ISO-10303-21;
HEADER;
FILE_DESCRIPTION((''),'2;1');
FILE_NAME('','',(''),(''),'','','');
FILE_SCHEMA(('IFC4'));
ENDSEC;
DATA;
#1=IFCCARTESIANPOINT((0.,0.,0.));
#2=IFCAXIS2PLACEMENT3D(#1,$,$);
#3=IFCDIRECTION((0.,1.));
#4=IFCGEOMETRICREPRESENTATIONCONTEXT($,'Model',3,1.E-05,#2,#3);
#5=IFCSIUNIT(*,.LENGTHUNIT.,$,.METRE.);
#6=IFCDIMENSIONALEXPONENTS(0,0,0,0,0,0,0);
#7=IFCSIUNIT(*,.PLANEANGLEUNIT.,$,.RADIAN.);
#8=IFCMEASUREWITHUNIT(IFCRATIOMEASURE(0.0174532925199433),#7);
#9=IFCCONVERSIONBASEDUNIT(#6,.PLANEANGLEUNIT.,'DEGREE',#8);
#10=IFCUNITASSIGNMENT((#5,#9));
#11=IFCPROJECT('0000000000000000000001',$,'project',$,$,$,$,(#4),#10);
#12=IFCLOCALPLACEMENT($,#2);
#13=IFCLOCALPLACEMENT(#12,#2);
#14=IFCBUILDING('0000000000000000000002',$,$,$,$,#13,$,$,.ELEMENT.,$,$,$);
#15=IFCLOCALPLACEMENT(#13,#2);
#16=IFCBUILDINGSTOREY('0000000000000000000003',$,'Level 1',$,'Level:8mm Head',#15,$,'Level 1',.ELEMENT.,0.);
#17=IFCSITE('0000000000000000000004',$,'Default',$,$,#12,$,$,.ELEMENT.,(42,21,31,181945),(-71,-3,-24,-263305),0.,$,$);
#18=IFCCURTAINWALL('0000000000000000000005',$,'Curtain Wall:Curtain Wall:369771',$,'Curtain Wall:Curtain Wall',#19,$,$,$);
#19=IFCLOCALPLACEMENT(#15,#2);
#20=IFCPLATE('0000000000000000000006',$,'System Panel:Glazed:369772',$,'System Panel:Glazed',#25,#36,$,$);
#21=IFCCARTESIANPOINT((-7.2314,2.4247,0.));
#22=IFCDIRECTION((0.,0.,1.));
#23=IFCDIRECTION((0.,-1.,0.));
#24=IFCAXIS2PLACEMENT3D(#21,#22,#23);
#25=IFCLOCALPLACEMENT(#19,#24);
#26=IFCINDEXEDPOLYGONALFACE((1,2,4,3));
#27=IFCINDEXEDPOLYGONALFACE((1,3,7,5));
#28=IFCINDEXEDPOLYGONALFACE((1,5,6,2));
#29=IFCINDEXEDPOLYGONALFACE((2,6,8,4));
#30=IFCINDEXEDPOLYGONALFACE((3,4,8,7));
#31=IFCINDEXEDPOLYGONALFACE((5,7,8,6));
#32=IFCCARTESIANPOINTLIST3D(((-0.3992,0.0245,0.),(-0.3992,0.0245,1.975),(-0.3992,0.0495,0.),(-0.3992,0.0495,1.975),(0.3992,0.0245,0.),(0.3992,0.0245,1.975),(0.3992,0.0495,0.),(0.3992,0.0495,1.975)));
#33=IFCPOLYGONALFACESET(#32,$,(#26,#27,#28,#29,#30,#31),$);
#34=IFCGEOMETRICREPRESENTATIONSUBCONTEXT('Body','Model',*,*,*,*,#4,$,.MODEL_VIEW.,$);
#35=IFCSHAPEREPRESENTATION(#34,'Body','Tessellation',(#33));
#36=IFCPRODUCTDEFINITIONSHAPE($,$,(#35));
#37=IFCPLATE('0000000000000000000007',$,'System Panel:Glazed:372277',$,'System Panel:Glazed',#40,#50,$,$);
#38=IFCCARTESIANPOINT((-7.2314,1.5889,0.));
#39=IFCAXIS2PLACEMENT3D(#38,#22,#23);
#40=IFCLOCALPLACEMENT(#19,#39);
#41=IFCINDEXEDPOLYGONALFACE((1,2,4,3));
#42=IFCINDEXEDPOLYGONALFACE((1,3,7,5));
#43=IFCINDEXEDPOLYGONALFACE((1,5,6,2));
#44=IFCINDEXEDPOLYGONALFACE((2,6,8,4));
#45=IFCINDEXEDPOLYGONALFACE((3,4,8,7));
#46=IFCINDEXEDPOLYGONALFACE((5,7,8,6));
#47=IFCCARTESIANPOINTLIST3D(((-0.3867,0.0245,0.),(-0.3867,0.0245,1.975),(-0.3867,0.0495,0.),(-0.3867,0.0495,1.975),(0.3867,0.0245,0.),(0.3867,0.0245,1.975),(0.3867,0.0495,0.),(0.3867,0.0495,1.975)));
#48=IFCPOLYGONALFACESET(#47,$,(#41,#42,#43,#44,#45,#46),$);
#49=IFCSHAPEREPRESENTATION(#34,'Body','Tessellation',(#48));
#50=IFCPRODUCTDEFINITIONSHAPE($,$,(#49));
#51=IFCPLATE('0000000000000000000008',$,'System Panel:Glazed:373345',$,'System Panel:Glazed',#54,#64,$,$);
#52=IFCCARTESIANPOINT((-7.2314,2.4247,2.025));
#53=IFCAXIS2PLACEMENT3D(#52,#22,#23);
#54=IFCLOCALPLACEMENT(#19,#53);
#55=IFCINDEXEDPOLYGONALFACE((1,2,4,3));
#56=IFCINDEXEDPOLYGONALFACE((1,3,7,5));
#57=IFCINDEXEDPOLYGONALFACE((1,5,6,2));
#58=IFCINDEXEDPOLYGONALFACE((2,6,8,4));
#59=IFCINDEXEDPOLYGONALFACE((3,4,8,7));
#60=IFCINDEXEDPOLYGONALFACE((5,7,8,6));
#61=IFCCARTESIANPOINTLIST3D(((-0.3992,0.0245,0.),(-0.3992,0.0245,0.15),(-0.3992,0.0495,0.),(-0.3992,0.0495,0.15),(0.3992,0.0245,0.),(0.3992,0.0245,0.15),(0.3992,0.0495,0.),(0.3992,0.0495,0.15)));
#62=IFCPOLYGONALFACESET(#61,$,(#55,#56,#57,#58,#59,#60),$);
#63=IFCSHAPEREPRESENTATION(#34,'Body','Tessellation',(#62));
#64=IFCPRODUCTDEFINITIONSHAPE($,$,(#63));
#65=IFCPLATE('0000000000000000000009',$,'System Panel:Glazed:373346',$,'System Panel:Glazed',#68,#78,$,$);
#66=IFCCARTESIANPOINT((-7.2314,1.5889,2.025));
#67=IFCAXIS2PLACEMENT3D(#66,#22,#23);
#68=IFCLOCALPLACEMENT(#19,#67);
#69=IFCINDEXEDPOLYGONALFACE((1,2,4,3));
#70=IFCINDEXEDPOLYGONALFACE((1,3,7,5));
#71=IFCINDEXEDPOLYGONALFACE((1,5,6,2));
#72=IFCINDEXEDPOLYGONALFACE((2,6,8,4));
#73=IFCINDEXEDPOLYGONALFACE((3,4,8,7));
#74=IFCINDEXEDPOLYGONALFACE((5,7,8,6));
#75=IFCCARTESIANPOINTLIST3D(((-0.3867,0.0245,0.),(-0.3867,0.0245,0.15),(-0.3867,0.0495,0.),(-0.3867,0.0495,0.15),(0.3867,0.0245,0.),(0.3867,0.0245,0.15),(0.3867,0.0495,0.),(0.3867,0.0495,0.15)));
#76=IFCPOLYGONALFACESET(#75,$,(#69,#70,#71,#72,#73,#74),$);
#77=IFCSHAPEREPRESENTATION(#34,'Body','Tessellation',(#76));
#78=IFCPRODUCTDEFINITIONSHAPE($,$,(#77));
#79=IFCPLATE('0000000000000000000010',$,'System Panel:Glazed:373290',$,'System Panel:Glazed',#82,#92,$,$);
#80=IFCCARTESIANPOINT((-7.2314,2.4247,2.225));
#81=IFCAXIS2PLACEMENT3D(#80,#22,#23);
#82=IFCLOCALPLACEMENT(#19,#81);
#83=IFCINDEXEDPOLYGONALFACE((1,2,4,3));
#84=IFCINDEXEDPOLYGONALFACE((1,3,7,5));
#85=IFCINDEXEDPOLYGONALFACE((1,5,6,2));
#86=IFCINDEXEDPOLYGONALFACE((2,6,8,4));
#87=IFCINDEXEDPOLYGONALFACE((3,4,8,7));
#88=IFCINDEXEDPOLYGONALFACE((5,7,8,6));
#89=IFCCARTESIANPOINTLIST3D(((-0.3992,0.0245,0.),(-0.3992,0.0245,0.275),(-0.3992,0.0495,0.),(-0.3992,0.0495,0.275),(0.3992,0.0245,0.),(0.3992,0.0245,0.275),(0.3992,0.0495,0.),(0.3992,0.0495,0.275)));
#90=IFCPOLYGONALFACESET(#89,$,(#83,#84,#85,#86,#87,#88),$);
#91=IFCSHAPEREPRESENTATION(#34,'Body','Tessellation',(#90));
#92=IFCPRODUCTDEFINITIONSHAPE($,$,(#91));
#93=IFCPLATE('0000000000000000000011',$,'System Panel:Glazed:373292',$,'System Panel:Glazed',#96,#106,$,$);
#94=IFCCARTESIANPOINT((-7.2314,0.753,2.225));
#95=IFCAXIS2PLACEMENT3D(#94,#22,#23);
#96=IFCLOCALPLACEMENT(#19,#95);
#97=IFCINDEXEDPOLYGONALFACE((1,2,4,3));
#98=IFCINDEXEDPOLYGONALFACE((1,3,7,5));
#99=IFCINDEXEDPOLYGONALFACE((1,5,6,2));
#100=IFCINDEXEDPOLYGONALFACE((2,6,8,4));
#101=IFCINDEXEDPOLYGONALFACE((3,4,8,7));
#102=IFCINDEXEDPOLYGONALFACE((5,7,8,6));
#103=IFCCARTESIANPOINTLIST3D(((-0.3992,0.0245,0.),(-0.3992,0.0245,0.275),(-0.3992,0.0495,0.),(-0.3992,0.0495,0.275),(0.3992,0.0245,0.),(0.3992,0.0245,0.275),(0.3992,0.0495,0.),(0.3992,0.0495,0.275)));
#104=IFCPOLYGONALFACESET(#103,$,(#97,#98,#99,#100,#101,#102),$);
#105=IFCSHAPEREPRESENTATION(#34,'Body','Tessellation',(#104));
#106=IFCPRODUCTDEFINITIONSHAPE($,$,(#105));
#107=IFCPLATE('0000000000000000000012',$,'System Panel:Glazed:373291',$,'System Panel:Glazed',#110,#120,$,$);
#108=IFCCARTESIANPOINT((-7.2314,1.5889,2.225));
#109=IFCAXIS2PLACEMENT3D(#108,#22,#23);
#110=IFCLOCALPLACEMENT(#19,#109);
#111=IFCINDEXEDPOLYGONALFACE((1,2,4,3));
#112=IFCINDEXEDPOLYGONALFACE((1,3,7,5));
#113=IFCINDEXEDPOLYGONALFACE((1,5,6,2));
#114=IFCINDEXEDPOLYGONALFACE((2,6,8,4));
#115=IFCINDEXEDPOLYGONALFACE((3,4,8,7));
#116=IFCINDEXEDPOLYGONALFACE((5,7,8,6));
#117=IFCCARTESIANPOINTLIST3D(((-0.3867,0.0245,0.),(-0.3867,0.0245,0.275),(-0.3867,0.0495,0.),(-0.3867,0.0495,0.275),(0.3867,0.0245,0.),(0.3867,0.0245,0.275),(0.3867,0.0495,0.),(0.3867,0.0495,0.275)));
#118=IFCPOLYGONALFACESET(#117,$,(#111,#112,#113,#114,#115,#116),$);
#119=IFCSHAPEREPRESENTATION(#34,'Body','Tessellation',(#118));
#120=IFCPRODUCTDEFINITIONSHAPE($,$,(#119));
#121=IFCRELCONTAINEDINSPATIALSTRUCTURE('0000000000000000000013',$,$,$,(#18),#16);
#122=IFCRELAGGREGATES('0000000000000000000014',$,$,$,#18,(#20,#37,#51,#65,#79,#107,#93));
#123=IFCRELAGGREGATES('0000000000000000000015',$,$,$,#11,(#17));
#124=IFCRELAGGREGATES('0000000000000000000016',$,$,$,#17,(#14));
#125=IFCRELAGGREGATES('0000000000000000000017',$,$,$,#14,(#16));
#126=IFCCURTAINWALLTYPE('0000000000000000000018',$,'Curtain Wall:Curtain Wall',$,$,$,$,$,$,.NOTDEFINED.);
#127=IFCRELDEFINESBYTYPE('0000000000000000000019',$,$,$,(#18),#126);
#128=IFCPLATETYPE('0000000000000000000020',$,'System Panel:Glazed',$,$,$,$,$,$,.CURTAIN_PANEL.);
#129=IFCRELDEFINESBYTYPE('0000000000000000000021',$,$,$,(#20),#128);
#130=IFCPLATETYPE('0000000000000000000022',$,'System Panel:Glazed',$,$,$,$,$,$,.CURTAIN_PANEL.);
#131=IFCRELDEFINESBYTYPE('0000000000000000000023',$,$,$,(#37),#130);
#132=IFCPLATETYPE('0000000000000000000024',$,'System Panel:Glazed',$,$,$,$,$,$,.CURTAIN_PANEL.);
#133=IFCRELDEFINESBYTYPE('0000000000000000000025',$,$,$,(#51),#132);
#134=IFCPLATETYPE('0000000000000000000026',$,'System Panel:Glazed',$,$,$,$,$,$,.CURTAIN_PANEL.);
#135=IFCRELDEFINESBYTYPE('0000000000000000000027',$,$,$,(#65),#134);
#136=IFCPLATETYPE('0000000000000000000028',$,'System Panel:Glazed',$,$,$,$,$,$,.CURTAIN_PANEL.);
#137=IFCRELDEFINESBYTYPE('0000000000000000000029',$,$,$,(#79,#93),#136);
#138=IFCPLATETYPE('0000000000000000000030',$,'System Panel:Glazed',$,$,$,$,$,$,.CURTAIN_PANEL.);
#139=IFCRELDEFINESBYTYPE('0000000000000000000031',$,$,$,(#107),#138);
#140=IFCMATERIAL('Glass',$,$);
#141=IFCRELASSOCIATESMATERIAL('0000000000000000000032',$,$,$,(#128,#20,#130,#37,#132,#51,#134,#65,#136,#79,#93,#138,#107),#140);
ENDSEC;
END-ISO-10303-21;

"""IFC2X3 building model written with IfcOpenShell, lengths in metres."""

from ifc_helpers import new_model, entity, si_unit, converted_unit, direction, frame, origin, origin_2d_with_axis, place, context, subcontext, project, spatial, rectangle, extrude, source, transform, mapped, material, type_object, type_shapes, element, aggregate, save


model = new_model("IFC2X3")

# Units and contexts
model_context = context("Model", 3, precision=1e-05, world=origin(), true_north=direction((0.0, 1.0)))
body_context = subcontext(model_context, "Body", "Model", "MODEL_VIEW")
ifc_project = project(units=[si_unit("LENGTHUNIT", "METRE"), converted_unit("PLANEANGLEUNIT", "DEGREE", entity("IfcRatioMeasure", 0.0174532925199433), si_unit("PLANEANGLEUNIT", "RADIAN"), dimensions=[0, 0, 0, 0, 0, 0, 0])], contexts=[model_context])

# Site, building, storey
site_placement = place(None, origin())
site = spatial("IfcSite", under=ifc_project, at=site_placement, Name="Default", CompositionType="ELEMENT", RefLatitude=(42, 21, 31, 181945), RefLongitude=(-71, -3, -24, -263305), RefElevation=0.0)
building_placement = place(site_placement, origin())
building = spatial("IfcBuilding", under=site, at=building_placement, CompositionType="ELEMENT")
storey_placement = place(building_placement, origin())
storey = spatial("IfcBuildingStorey", under=building, at=storey_placement, Name="Level 1", ObjectType="Level:8mm Head", LongName="Level 1", CompositionType="ELEMENT", Elevation=0.0)

# Curtain wall, plates
curtain_wall_type = type_object("IfcCurtainWallType", Name="Curtain Wall:Curtain Wall", PredefinedType="NOTDEFINED")
curtain_wall_placement = place(storey_placement, origin())
curtain_wall = element("IfcCurtainWall", 1, at=curtain_wall_placement, inside=storey, type_object=curtain_wall_type, Name="Curtain Wall:Curtain Wall:369771", ObjectType="Curtain Wall:Curtain Wall")
ifc_material_1 = material(Name="Glass")
plate_type_1 = type_object("IfcPlateType", Name="System Panel:Glazed", PredefinedType="CURTAIN_PANEL", material=ifc_material_1)
shared_shape_1 = source(origin(), body_context, "Body", "SweptSolid", [
    extrude(rectangle(XDim=0.025, YDim=0.7983, at=origin_2d_with_axis()), frame((0.0, 0.037, 0.0), z_axis=(0.0, 0.0, 1.0), x_axis=(0.0, 1.0, 0.0)), (0.0, 0.0, 1.0), 1.975),
])
type_shapes(plate_type_1, [shared_shape_1])
plate_1_placement = place(curtain_wall_placement, frame((-7.2314, 2.4247, 0.0), z_axis=(0.0, 0.0, 1.0), x_axis=(0.0, -1.0, 0.0)))
plate_1 = element("IfcPlate", 2, at=plate_1_placement, type_object=plate_type_1, material=ifc_material_1, Name="System Panel:Glazed:369772", ObjectType="System Panel:Glazed", context=body_context, shape_type="MappedRepresentation", body=[
    mapped(shared_shape_1, transform((0.0, 0.0, 0.0), scale=1.0)),
])
plate_type_2 = type_object("IfcPlateType", Name="System Panel:Glazed", PredefinedType="CURTAIN_PANEL", material=ifc_material_1)
shared_shape_2 = source(origin(), body_context, "Body", "SweptSolid", [
    extrude(rectangle(XDim=0.025, YDim=0.7733, at=origin_2d_with_axis()), frame((0.0, 0.037, 0.0), z_axis=(0.0, 0.0, 1.0), x_axis=(0.0, 1.0, 0.0)), (0.0, 0.0, 1.0), 1.975),
])
type_shapes(plate_type_2, [shared_shape_2])
plate_2_placement = place(curtain_wall_placement, frame((-7.2314, 1.5889, 0.0), z_axis=(0.0, 0.0, 1.0), x_axis=(0.0, -1.0, 0.0)))
plate_2 = element("IfcPlate", 3, at=plate_2_placement, type_object=plate_type_2, material=ifc_material_1, Name="System Panel:Glazed:372277", ObjectType="System Panel:Glazed", context=body_context, shape_type="MappedRepresentation", body=[
    mapped(shared_shape_2, transform((0.0, 0.0, 0.0), scale=1.0)),
])
plate_type_3 = type_object("IfcPlateType", Name="System Panel:Glazed", PredefinedType="CURTAIN_PANEL", material=ifc_material_1)
shared_shape_3 = source(origin(), body_context, "Body", "SweptSolid", [
    extrude(rectangle(XDim=0.025, YDim=0.7983, at=origin_2d_with_axis()), frame((0.0, 0.037, 0.0), z_axis=(0.0, 0.0, 1.0), x_axis=(0.0, 1.0, 0.0)), (0.0, 0.0, 1.0), 0.15),
])
type_shapes(plate_type_3, [shared_shape_3])
plate_3_placement = place(curtain_wall_placement, frame((-7.2314, 2.4247, 2.025), z_axis=(0.0, 0.0, 1.0), x_axis=(0.0, -1.0, 0.0)))
plate_3 = element("IfcPlate", 4, at=plate_3_placement, type_object=plate_type_3, material=ifc_material_1, Name="System Panel:Glazed:373345", ObjectType="System Panel:Glazed", context=body_context, shape_type="MappedRepresentation", body=[
    mapped(shared_shape_3, transform((0.0, 0.0, 0.0), scale=1.0)),
])
plate_type_4 = type_object("IfcPlateType", Name="System Panel:Glazed", PredefinedType="CURTAIN_PANEL", material=ifc_material_1)
shared_shape_4 = source(origin(), body_context, "Body", "SweptSolid", [
    extrude(rectangle(XDim=0.025, YDim=0.7733, at=origin_2d_with_axis()), frame((0.0, 0.037, 0.0), z_axis=(0.0, 0.0, 1.0), x_axis=(0.0, 1.0, 0.0)), (0.0, 0.0, 1.0), 0.15),
])
type_shapes(plate_type_4, [shared_shape_4])
plate_4_placement = place(curtain_wall_placement, frame((-7.2314, 1.5889, 2.025), z_axis=(0.0, 0.0, 1.0), x_axis=(0.0, -1.0, 0.0)))
plate_4 = element("IfcPlate", 5, at=plate_4_placement, type_object=plate_type_4, material=ifc_material_1, Name="System Panel:Glazed:373346", ObjectType="System Panel:Glazed", context=body_context, shape_type="MappedRepresentation", body=[
    mapped(shared_shape_4, transform((0.0, 0.0, 0.0), scale=1.0)),
])
plate_type_5 = type_object("IfcPlateType", Name="System Panel:Glazed", PredefinedType="CURTAIN_PANEL", material=ifc_material_1)
shared_shape_5 = source(origin(), body_context, "Body", "SweptSolid", [
    extrude(rectangle(XDim=0.025, YDim=0.7983, at=origin_2d_with_axis()), frame((0.0, 0.037, 0.0), z_axis=(0.0, 0.0, 1.0), x_axis=(0.0, 1.0, 0.0)), (0.0, 0.0, 1.0), 0.275),
])
type_shapes(plate_type_5, [shared_shape_5])
plate_5_placement = place(curtain_wall_placement, frame((-7.2314, 2.4247, 2.225), z_axis=(0.0, 0.0, 1.0), x_axis=(0.0, -1.0, 0.0)))
plate_5 = element("IfcPlate", 6, at=plate_5_placement, type_object=plate_type_5, material=ifc_material_1, Name="System Panel:Glazed:373290", ObjectType="System Panel:Glazed", context=body_context, shape_type="MappedRepresentation", body=[
    mapped(shared_shape_5, transform((0.0, 0.0, 0.0), scale=1.0)),
])
plate_6_placement = place(curtain_wall_placement, frame((-7.2314, 0.753, 2.225), z_axis=(0.0, 0.0, 1.0), x_axis=(0.0, -1.0, 0.0)))
plate_6 = element("IfcPlate", 7, at=plate_6_placement, type_object=plate_type_5, material=ifc_material_1, Name="System Panel:Glazed:373292", ObjectType="System Panel:Glazed", context=body_context, shape_type="MappedRepresentation", body=[
    mapped(shared_shape_5, transform((0.0, 0.0, 0.0), scale=1.0)),
])
plate_type_6 = type_object("IfcPlateType", Name="System Panel:Glazed", PredefinedType="CURTAIN_PANEL", material=ifc_material_1)
shared_shape_6 = source(origin(), body_context, "Body", "SweptSolid", [
    extrude(rectangle(XDim=0.025, YDim=0.7733, at=origin_2d_with_axis()), frame((0.0, 0.037, 0.0), z_axis=(0.0, 0.0, 1.0), x_axis=(0.0, 1.0, 0.0)), (0.0, 0.0, 1.0), 0.275),
])
type_shapes(plate_type_6, [shared_shape_6])
plate_7_placement = place(curtain_wall_placement, frame((-7.2314, 1.5889, 2.225), z_axis=(0.0, 0.0, 1.0), x_axis=(0.0, -1.0, 0.0)))
plate_7 = element("IfcPlate", 8, at=plate_7_placement, type_object=plate_type_6, material=ifc_material_1, Name="System Panel:Glazed:373291", ObjectType="System Panel:Glazed", context=body_context, shape_type="MappedRepresentation", body=[
    mapped(shared_shape_6, transform((0.0, 0.0, 0.0), scale=1.0)),
])
aggregate(curtain_wall, [plate_1, plate_2, plate_3, plate_4, plate_5, plate_7, plate_6])

save(model, "model.ifc")
